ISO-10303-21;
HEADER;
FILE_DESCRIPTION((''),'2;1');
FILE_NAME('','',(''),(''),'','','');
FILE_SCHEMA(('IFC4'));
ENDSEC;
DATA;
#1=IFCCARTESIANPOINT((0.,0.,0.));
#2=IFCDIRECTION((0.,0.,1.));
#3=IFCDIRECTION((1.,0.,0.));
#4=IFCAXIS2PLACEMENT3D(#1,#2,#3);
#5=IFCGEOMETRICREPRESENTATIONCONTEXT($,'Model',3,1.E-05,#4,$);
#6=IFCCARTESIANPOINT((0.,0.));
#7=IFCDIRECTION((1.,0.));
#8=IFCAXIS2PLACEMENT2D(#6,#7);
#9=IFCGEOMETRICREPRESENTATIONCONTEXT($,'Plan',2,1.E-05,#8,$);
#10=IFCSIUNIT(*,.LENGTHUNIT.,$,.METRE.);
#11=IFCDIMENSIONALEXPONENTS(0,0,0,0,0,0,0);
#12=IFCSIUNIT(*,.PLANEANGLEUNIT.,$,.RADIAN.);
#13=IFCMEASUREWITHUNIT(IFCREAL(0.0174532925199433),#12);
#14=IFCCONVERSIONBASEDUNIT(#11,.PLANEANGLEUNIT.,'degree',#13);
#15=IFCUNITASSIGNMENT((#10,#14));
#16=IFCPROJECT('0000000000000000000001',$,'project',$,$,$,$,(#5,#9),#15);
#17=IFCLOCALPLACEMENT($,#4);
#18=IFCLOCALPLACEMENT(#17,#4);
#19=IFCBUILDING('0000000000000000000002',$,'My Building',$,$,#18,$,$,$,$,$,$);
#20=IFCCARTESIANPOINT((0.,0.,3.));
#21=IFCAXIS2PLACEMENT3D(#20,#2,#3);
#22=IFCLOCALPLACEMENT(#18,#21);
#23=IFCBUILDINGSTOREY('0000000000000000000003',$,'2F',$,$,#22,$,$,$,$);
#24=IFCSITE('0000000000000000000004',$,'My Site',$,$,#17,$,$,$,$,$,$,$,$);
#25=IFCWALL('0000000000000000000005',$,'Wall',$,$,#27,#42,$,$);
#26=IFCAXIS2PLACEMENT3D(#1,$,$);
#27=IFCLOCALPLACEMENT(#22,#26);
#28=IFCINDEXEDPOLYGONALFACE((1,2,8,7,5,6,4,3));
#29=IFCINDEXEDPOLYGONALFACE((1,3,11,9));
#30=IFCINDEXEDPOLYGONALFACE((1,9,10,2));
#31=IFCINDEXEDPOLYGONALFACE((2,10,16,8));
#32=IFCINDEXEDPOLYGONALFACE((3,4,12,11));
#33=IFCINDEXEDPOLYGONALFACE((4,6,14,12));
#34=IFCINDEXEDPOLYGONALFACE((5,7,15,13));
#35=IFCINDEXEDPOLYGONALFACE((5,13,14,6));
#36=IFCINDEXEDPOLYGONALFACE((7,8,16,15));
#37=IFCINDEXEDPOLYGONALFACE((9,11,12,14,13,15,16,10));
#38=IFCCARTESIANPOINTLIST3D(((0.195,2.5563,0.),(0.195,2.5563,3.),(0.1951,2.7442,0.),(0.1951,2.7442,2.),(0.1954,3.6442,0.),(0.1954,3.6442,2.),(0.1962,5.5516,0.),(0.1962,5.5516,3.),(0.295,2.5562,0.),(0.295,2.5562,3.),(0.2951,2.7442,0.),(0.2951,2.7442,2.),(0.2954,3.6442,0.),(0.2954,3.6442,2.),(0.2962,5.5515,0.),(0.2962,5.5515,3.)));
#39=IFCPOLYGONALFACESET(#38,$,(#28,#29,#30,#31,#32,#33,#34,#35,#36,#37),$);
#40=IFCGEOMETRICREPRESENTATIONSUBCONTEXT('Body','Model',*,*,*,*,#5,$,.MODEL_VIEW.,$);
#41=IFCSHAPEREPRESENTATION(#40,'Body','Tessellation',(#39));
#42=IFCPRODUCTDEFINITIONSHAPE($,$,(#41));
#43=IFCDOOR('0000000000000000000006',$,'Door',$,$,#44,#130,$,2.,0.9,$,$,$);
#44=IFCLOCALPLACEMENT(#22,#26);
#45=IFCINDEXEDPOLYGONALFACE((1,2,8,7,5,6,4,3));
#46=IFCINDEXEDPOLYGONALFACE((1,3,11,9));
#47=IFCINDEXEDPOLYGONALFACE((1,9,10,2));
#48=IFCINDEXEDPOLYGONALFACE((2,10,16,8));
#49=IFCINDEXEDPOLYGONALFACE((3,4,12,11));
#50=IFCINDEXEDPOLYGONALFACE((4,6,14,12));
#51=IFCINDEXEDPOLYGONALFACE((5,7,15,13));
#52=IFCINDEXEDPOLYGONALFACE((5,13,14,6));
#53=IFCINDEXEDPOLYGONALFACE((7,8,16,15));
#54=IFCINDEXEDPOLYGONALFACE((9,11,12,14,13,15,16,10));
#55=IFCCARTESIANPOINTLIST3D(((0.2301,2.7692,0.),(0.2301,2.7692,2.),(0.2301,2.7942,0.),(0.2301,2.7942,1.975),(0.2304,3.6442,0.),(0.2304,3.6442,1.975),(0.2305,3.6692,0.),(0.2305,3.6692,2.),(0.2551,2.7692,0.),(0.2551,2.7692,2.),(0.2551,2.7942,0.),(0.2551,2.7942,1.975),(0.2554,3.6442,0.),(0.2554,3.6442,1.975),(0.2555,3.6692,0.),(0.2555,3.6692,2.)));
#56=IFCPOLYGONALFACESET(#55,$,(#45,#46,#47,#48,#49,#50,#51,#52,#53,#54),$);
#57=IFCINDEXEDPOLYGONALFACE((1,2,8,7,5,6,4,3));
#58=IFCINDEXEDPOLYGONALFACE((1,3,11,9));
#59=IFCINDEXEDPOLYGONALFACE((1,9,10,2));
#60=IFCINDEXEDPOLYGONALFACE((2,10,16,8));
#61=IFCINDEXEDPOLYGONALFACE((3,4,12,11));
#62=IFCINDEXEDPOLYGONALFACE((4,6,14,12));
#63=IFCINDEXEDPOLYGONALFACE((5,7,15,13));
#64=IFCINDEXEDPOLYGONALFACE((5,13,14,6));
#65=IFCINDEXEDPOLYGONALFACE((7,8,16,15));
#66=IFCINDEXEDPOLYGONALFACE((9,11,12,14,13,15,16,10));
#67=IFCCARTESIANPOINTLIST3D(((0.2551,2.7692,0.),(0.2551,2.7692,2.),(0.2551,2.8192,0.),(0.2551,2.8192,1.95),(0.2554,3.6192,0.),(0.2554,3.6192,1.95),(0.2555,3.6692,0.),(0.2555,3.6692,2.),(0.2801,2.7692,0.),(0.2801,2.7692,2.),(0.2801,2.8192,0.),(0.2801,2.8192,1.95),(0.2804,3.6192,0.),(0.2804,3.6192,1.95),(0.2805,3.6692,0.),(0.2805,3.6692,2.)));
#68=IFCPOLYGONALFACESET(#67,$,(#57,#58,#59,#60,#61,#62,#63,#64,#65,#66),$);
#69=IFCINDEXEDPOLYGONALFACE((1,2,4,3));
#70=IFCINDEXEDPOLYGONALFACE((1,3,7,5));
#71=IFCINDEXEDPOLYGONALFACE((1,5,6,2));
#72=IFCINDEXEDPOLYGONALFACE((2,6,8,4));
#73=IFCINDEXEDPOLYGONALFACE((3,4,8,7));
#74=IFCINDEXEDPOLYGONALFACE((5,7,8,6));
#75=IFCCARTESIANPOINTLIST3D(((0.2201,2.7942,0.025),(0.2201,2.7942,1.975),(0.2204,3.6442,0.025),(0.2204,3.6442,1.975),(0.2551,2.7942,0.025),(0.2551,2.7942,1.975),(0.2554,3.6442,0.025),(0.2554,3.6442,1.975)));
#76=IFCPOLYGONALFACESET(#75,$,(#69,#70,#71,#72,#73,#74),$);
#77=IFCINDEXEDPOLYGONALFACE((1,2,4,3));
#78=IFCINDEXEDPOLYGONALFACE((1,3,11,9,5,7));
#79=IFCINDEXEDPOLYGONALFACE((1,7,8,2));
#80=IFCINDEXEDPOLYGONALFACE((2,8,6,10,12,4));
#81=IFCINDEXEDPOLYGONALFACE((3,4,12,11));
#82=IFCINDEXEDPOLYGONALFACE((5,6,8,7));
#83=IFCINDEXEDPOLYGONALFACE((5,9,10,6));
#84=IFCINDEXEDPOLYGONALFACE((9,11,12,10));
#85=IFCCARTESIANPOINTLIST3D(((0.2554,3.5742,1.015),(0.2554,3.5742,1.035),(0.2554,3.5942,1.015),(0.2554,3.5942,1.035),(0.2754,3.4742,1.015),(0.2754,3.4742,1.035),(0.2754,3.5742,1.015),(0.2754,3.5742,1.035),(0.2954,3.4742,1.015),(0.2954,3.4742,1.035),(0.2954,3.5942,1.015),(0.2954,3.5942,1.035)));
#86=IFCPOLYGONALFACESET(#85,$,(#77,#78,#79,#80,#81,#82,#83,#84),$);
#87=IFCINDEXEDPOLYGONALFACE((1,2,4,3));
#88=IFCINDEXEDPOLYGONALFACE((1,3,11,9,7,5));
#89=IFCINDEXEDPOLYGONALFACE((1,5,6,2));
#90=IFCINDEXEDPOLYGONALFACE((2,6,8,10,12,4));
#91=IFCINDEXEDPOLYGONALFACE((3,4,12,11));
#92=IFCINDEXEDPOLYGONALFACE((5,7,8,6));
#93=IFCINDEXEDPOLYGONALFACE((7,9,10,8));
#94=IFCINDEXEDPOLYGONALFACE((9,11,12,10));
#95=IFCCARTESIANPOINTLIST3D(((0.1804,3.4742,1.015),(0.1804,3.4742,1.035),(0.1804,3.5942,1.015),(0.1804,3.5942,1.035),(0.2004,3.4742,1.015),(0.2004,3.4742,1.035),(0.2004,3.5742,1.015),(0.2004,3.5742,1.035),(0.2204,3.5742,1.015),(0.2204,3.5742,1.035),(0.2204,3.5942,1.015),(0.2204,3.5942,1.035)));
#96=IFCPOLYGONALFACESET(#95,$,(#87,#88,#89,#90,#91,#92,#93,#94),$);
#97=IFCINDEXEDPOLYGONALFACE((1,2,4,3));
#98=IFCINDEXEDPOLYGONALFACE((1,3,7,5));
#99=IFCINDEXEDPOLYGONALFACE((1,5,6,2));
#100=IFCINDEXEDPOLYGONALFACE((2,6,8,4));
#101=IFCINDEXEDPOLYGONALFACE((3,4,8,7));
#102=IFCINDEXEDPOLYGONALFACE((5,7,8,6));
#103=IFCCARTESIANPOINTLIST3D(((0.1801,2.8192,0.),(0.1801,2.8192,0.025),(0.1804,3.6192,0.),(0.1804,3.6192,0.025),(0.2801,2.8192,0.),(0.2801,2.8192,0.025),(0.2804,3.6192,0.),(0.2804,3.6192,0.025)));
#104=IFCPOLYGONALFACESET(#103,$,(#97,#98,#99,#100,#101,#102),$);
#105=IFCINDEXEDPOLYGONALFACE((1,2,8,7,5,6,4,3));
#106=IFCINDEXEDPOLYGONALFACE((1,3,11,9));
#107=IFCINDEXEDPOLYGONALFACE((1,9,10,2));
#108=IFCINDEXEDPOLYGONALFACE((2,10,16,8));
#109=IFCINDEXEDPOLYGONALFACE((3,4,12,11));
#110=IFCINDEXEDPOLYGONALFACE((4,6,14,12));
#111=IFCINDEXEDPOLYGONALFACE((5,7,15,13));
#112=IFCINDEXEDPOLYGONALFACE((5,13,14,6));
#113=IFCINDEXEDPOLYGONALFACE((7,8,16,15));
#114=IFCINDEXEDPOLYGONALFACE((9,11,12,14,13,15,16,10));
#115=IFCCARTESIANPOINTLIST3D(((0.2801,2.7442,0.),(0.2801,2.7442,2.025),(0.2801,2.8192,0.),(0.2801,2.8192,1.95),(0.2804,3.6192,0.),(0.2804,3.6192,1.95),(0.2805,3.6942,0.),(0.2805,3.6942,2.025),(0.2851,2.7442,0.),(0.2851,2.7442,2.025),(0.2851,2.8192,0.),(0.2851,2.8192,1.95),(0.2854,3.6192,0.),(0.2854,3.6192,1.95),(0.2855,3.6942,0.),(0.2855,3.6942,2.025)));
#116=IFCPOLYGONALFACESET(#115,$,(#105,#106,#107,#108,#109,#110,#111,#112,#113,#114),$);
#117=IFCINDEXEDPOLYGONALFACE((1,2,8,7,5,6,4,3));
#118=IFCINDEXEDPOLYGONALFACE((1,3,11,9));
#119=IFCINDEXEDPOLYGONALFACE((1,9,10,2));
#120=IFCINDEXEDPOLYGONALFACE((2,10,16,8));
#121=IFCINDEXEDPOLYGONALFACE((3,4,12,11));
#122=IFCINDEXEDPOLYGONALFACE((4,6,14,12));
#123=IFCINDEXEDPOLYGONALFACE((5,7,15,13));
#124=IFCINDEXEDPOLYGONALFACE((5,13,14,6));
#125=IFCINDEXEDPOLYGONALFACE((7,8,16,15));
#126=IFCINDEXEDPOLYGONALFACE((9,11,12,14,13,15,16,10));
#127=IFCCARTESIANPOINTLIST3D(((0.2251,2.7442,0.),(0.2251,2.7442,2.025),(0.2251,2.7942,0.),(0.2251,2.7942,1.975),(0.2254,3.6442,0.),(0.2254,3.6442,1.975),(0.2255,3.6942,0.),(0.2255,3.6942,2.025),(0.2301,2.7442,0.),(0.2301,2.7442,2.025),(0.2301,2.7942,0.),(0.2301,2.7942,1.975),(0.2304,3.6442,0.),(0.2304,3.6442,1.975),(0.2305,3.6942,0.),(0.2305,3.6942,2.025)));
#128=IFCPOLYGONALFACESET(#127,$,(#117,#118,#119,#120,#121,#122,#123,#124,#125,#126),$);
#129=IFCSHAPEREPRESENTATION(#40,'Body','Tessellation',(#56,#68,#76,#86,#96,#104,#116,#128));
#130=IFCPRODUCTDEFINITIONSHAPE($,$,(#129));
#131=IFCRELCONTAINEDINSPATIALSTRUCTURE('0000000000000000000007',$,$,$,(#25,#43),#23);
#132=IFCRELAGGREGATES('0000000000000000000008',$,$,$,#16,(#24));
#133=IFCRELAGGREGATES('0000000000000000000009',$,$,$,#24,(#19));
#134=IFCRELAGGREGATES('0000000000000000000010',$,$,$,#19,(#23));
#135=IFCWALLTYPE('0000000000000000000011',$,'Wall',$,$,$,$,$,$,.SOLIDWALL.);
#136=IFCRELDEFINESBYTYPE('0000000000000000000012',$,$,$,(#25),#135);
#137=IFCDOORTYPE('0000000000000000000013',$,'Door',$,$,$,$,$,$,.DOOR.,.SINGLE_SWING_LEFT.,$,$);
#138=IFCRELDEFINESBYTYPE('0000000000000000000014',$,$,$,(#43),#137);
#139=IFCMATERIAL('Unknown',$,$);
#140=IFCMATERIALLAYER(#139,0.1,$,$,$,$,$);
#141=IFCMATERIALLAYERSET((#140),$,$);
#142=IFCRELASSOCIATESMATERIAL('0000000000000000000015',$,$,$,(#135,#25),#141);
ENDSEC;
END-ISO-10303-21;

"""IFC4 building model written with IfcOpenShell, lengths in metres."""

from ifc_helpers import new_model, entity, si_unit, converted_unit, frame, origin_with_axes, origin_2d_with_axis, place, context, subcontext, project, spatial, line, indexed_curve, outline, extrude, shape, source, transform, mapped, material, layer, layer_set, layer_usage, type_object, type_shapes, element, fill, save


model = new_model("IFC4")

# Units and contexts
model_context = context("Model", 3, precision=1e-05, world=origin_with_axes())
plan_context = context("Plan", 2, precision=1e-05, world=origin_2d_with_axis())
body_context_1 = subcontext(model_context, "Body", "Model", "MODEL_VIEW")
body_context_2 = subcontext(plan_context, "Body", "Plan", "PLAN_VIEW")
ifc_project = project(units=[si_unit("LENGTHUNIT", "METRE"), converted_unit("PLANEANGLEUNIT", "degree", entity("IfcReal", 0.0174532925199433), si_unit("PLANEANGLEUNIT", "RADIAN"), dimensions=[0, 0, 0, 0, 0, 0, 0])], contexts=[model_context, plan_context])

# Site, building, storey
site_placement = place(None, origin_with_axes())
site = spatial("IfcSite", under=ifc_project, at=site_placement, Name="My Site")
building_placement = place(site_placement, origin_with_axes())
building = spatial("IfcBuilding", under=site, at=building_placement, Name="My Building")
storey_placement = place(building_placement, frame((0.0, 0.0, 3.0), z_axis=(0.0, 0.0, 1.0), x_axis=(1.0, 0.0, 0.0)))
storey = spatial("IfcBuildingStorey", under=building, at=storey_placement, Name="2F")

# Shared definitions
ifc_material = material(Name="Unknown")

# Shared definitions
ifc_layer_1 = layer(ifc_material, 0.1)
ifc_layer_set_1 = layer_set([ifc_layer_1])
wall_type = type_object("IfcWallType", Name="Wall", PredefinedType="SOLIDWALL", material=ifc_layer_set_1)

# Wall, opening, door
ifc_layer_usage_1 = layer_usage(ifc_layer_set_1, "AXIS2", "POSITIVE", 0.0)
wall_1_placement = place(storey_placement, frame((0.1962, 5.5516, 0.0), z_axis=(0.0, 0.0, 1.0), x_axis=(-0.000399, -1.0, 0.0)))
wall_1 = element("IfcWall", 1, at=wall_1_placement, inside=storey, type_object=wall_type, material=ifc_layer_usage_1, Name="Wall", context=body_context_1, shape_type="SweptSolid", body=[
    extrude(outline(indexed_curve([(0.0, 0.0), (0.0, 0.1), (2.9953, 0.1), (2.9953, 0.0)], segments=[line(1, 2, 3, 4, 1)])), origin_with_axes(), (0.0, 0.0, 1.0), 3.0),
])
shared_shape_1 = source(origin_with_axes(), body_context_1, "Body", "SweptSolid", [
    extrude(outline(indexed_curve([(0.0, 0.0), (0.9, 0.0), (0.9, 2.0), (0.0, 2.0)], segments=[line(1, 2, 3, 4, 1)])), frame((0.0, -0.6, 0.0), z_axis=(0.0, -1.0, 0.0), x_axis=(1.0, 0.0, 0.0)), (0.0, 0.0, -1.0), 1.2),
])
opening_1_placement = place(wall_1_placement, frame((1.9074, 0.0, 0.0), z_axis=(0.0, 0.0, 1.0), x_axis=(1.0, 0.0, 0.0)))
opening_1 = element("IfcOpeningElement", 2, at=opening_1_placement, cuts=wall_1, PredefinedType="OPENING", context=body_context_1, shape_type="MappedRepresentation", body=[
    mapped(shared_shape_1, transform((0.0, 0.0, 0.0), x_axis=(1.0, 0.0, 0.0), y_axis=(0.0, 1.0, 0.0), z_axis=(0.0, 0.0, 1.0), scale=1.0)),
])
door_type_1 = type_object("IfcDoorType", Name="Door", OperationType="SINGLE_SWING_LEFT", PredefinedType="DOOR")
shared_shape_2 = source(origin_with_axes(), body_context_1, "Body", "SweptSolid", [
    extrude(outline(indexed_curve([(0.0, 0.0), (0.0, 2.0), (0.9, 2.0), (0.9, 0.0), (0.875, 0.0), (0.875, 1.975), (0.025, 1.975), (0.025, 0.0)], segments=[line(1, 2, 3, 4, 5, 6, 7, 8, 1)])), frame((0.0, 0.025, 0.0), z_axis=(0.0, -1.0, 0.0), x_axis=(1.0, 0.0, 0.0)), (0.0, 0.0, -1.0), 0.025),
    extrude(outline(indexed_curve([(0.0, 0.0), (0.0, 2.0), (0.9, 2.0), (0.9, 0.0), (0.85, 0.0), (0.85, 1.95), (0.05, 1.95), (0.05, 0.0)], segments=[line(1, 2, 3, 4, 5, 6, 7, 8, 1)])), frame((0.0, 0.0, 0.0), z_axis=(0.0, -1.0, 0.0), x_axis=(1.0, 0.0, 0.0)), (0.0, 0.0, -1.0), 0.025),
    extrude(outline(indexed_curve([(0.0, 0.0), (0.85, 0.0), (0.85, 0.035), (0.0, 0.035)], segments=[line(1, 2, 3, 4, 1)])), frame((0.025, 0.025, 0.025), z_axis=(0.0, 0.0, 1.0), x_axis=(1.0, 0.0, 0.0)), (0.0, 0.0, 1.0), 1.95),
    extrude(outline(indexed_curve([(0.0, 0.0), (0.0, -0.04), (-0.12, -0.04), (-0.12, -0.02), (-0.02, -0.02), (-0.02, 0.0)], segments=[line(1, 2, 3, 4, 5, 6, 1)])), frame((0.825, 0.025, 1.015), z_axis=(0.0, 0.0, 1.0), x_axis=(1.0, 0.0, 0.0)), (0.0, 0.0, 1.0), 0.02),
    extrude(outline(indexed_curve([(0.0, 0.0), (0.0, 0.04), (-0.12, 0.04), (-0.12, 0.02), (-0.02, 0.02), (-0.02, 0.0)], segments=[line(1, 2, 3, 4, 5, 6, 1)])), frame((0.825, 0.06, 1.015), z_axis=(0.0, 0.0, 1.0), x_axis=(1.0, 0.0, 0.0)), (0.0, 0.0, 1.0), 0.02),
    extrude(outline(indexed_curve([(0.0, 0.0), (0.8, 0.0), (0.8, 0.1), (0.0, 0.1)], segments=[line(1, 2, 3, 4, 1)])), frame((0.05, 0.0, 0.0), z_axis=(0.0, 0.0, 1.0), x_axis=(1.0, 0.0, 0.0)), (0.0, 0.0, 1.0), 0.025),
    extrude(outline(indexed_curve([(0.0, 0.0), (0.0, 2.025), (0.95, 2.025), (0.95, 0.0), (0.875, 0.0), (0.875, 1.95), (0.075, 1.95), (0.075, 0.0)], segments=[line(1, 2, 3, 4, 5, 6, 7, 8, 1)])), frame((-0.025, -0.005, 0.0), z_axis=(0.0, -1.0, 0.0), x_axis=(1.0, 0.0, 0.0)), (0.0, 0.0, -1.0), 0.005),
    extrude(outline(indexed_curve([(0.0, 0.0), (0.0, 2.025), (0.95, 2.025), (0.95, 0.0), (0.9, 0.0), (0.9, 1.975), (0.05, 1.975), (0.05, 0.0)], segments=[line(1, 2, 3, 4, 5, 6, 7, 8, 1)])), frame((-0.025, 0.05, 0.0), z_axis=(0.0, -1.0, 0.0), x_axis=(1.0, 0.0, 0.0)), (0.0, 0.0, -1.0), 0.005),
])
shared_shape_3 = source(origin_with_axes(), body_context_2, "Body", "Curve2D", [
    entity("IfcIndexedPolyCurve", entity("IfcCartesianPointList2D", [[0.0, 0.0], [0.0, 0.05], [0.025, 0.05], [0.025, 0.025], [0.05, 0.025], [0.05, 0.0]]), [entity("IfcLineIndex", [1, 2, 3, 4, 5, 6, 1])]),
    entity("IfcIndexedPolyCurve", entity("IfcCartesianPointList2D", [[0.9, 0.0], [0.9, 0.05], [0.875, 0.05], [0.875, 0.025], [0.85, 0.025], [0.85, 0.0]]), [entity("IfcLineIndex", [1, 2, 3, 4, 5, 6, 1])]),
    entity("IfcTrimmedCurve", entity("IfcEllipse", entity("IfcAxis2Placement2D", entity("IfcCartesianPoint", [0.06, 0.05]), entity("IfcDirection", [1.0, 0.0])), 0.815, 0.85), [entity("IfcCartesianPoint", [0.875, 0.05])], [entity("IfcCartesianPoint", [0.06, 0.9])], True, "CARTESIAN"),
    entity("IfcIndexedPolyCurve", entity("IfcCartesianPointList2D", [[0.025, 0.05], [0.06, 0.05], [0.06, 0.9], [0.025, 0.9]]), [entity("IfcLineIndex", [1, 2, 3, 4, 1])]),
])
type_shapes(door_type_1, [shared_shape_2, shared_shape_3])
door_1_placement = place(opening_1_placement, frame((0.875, 0.085, 0.0), z_axis=(0.0, 0.0, 1.0), x_axis=(-1.0, 0.0, 0.0)))
door_1 = element("IfcDoor", 3, at=door_1_placement, inside=storey, type_object=door_type_1, Name="Door", OverallHeight=2.0, OverallWidth=0.9, shapes=[
    shape(body_context_1, "Body", "MappedRepresentation", [mapped(shared_shape_2, transform((0.0, 0.0, 0.0), x_axis=(1.0, 0.0, 0.0), y_axis=(0.0, 1.0, 0.0), z_axis=(0.0, 0.0, 1.0), scale=1.0))]),
    shape(body_context_2, "Body", "MappedRepresentation", [mapped(shared_shape_3, transform((0.0, 0.0, 0.0), x_axis=(1.0, 0.0, 0.0), y_axis=(0.0, 1.0, 0.0), z_axis=(0.0, 0.0, 1.0), scale=1.0))]),
])
fill(opening_1, door_1)

save(model, "model.ifc")
